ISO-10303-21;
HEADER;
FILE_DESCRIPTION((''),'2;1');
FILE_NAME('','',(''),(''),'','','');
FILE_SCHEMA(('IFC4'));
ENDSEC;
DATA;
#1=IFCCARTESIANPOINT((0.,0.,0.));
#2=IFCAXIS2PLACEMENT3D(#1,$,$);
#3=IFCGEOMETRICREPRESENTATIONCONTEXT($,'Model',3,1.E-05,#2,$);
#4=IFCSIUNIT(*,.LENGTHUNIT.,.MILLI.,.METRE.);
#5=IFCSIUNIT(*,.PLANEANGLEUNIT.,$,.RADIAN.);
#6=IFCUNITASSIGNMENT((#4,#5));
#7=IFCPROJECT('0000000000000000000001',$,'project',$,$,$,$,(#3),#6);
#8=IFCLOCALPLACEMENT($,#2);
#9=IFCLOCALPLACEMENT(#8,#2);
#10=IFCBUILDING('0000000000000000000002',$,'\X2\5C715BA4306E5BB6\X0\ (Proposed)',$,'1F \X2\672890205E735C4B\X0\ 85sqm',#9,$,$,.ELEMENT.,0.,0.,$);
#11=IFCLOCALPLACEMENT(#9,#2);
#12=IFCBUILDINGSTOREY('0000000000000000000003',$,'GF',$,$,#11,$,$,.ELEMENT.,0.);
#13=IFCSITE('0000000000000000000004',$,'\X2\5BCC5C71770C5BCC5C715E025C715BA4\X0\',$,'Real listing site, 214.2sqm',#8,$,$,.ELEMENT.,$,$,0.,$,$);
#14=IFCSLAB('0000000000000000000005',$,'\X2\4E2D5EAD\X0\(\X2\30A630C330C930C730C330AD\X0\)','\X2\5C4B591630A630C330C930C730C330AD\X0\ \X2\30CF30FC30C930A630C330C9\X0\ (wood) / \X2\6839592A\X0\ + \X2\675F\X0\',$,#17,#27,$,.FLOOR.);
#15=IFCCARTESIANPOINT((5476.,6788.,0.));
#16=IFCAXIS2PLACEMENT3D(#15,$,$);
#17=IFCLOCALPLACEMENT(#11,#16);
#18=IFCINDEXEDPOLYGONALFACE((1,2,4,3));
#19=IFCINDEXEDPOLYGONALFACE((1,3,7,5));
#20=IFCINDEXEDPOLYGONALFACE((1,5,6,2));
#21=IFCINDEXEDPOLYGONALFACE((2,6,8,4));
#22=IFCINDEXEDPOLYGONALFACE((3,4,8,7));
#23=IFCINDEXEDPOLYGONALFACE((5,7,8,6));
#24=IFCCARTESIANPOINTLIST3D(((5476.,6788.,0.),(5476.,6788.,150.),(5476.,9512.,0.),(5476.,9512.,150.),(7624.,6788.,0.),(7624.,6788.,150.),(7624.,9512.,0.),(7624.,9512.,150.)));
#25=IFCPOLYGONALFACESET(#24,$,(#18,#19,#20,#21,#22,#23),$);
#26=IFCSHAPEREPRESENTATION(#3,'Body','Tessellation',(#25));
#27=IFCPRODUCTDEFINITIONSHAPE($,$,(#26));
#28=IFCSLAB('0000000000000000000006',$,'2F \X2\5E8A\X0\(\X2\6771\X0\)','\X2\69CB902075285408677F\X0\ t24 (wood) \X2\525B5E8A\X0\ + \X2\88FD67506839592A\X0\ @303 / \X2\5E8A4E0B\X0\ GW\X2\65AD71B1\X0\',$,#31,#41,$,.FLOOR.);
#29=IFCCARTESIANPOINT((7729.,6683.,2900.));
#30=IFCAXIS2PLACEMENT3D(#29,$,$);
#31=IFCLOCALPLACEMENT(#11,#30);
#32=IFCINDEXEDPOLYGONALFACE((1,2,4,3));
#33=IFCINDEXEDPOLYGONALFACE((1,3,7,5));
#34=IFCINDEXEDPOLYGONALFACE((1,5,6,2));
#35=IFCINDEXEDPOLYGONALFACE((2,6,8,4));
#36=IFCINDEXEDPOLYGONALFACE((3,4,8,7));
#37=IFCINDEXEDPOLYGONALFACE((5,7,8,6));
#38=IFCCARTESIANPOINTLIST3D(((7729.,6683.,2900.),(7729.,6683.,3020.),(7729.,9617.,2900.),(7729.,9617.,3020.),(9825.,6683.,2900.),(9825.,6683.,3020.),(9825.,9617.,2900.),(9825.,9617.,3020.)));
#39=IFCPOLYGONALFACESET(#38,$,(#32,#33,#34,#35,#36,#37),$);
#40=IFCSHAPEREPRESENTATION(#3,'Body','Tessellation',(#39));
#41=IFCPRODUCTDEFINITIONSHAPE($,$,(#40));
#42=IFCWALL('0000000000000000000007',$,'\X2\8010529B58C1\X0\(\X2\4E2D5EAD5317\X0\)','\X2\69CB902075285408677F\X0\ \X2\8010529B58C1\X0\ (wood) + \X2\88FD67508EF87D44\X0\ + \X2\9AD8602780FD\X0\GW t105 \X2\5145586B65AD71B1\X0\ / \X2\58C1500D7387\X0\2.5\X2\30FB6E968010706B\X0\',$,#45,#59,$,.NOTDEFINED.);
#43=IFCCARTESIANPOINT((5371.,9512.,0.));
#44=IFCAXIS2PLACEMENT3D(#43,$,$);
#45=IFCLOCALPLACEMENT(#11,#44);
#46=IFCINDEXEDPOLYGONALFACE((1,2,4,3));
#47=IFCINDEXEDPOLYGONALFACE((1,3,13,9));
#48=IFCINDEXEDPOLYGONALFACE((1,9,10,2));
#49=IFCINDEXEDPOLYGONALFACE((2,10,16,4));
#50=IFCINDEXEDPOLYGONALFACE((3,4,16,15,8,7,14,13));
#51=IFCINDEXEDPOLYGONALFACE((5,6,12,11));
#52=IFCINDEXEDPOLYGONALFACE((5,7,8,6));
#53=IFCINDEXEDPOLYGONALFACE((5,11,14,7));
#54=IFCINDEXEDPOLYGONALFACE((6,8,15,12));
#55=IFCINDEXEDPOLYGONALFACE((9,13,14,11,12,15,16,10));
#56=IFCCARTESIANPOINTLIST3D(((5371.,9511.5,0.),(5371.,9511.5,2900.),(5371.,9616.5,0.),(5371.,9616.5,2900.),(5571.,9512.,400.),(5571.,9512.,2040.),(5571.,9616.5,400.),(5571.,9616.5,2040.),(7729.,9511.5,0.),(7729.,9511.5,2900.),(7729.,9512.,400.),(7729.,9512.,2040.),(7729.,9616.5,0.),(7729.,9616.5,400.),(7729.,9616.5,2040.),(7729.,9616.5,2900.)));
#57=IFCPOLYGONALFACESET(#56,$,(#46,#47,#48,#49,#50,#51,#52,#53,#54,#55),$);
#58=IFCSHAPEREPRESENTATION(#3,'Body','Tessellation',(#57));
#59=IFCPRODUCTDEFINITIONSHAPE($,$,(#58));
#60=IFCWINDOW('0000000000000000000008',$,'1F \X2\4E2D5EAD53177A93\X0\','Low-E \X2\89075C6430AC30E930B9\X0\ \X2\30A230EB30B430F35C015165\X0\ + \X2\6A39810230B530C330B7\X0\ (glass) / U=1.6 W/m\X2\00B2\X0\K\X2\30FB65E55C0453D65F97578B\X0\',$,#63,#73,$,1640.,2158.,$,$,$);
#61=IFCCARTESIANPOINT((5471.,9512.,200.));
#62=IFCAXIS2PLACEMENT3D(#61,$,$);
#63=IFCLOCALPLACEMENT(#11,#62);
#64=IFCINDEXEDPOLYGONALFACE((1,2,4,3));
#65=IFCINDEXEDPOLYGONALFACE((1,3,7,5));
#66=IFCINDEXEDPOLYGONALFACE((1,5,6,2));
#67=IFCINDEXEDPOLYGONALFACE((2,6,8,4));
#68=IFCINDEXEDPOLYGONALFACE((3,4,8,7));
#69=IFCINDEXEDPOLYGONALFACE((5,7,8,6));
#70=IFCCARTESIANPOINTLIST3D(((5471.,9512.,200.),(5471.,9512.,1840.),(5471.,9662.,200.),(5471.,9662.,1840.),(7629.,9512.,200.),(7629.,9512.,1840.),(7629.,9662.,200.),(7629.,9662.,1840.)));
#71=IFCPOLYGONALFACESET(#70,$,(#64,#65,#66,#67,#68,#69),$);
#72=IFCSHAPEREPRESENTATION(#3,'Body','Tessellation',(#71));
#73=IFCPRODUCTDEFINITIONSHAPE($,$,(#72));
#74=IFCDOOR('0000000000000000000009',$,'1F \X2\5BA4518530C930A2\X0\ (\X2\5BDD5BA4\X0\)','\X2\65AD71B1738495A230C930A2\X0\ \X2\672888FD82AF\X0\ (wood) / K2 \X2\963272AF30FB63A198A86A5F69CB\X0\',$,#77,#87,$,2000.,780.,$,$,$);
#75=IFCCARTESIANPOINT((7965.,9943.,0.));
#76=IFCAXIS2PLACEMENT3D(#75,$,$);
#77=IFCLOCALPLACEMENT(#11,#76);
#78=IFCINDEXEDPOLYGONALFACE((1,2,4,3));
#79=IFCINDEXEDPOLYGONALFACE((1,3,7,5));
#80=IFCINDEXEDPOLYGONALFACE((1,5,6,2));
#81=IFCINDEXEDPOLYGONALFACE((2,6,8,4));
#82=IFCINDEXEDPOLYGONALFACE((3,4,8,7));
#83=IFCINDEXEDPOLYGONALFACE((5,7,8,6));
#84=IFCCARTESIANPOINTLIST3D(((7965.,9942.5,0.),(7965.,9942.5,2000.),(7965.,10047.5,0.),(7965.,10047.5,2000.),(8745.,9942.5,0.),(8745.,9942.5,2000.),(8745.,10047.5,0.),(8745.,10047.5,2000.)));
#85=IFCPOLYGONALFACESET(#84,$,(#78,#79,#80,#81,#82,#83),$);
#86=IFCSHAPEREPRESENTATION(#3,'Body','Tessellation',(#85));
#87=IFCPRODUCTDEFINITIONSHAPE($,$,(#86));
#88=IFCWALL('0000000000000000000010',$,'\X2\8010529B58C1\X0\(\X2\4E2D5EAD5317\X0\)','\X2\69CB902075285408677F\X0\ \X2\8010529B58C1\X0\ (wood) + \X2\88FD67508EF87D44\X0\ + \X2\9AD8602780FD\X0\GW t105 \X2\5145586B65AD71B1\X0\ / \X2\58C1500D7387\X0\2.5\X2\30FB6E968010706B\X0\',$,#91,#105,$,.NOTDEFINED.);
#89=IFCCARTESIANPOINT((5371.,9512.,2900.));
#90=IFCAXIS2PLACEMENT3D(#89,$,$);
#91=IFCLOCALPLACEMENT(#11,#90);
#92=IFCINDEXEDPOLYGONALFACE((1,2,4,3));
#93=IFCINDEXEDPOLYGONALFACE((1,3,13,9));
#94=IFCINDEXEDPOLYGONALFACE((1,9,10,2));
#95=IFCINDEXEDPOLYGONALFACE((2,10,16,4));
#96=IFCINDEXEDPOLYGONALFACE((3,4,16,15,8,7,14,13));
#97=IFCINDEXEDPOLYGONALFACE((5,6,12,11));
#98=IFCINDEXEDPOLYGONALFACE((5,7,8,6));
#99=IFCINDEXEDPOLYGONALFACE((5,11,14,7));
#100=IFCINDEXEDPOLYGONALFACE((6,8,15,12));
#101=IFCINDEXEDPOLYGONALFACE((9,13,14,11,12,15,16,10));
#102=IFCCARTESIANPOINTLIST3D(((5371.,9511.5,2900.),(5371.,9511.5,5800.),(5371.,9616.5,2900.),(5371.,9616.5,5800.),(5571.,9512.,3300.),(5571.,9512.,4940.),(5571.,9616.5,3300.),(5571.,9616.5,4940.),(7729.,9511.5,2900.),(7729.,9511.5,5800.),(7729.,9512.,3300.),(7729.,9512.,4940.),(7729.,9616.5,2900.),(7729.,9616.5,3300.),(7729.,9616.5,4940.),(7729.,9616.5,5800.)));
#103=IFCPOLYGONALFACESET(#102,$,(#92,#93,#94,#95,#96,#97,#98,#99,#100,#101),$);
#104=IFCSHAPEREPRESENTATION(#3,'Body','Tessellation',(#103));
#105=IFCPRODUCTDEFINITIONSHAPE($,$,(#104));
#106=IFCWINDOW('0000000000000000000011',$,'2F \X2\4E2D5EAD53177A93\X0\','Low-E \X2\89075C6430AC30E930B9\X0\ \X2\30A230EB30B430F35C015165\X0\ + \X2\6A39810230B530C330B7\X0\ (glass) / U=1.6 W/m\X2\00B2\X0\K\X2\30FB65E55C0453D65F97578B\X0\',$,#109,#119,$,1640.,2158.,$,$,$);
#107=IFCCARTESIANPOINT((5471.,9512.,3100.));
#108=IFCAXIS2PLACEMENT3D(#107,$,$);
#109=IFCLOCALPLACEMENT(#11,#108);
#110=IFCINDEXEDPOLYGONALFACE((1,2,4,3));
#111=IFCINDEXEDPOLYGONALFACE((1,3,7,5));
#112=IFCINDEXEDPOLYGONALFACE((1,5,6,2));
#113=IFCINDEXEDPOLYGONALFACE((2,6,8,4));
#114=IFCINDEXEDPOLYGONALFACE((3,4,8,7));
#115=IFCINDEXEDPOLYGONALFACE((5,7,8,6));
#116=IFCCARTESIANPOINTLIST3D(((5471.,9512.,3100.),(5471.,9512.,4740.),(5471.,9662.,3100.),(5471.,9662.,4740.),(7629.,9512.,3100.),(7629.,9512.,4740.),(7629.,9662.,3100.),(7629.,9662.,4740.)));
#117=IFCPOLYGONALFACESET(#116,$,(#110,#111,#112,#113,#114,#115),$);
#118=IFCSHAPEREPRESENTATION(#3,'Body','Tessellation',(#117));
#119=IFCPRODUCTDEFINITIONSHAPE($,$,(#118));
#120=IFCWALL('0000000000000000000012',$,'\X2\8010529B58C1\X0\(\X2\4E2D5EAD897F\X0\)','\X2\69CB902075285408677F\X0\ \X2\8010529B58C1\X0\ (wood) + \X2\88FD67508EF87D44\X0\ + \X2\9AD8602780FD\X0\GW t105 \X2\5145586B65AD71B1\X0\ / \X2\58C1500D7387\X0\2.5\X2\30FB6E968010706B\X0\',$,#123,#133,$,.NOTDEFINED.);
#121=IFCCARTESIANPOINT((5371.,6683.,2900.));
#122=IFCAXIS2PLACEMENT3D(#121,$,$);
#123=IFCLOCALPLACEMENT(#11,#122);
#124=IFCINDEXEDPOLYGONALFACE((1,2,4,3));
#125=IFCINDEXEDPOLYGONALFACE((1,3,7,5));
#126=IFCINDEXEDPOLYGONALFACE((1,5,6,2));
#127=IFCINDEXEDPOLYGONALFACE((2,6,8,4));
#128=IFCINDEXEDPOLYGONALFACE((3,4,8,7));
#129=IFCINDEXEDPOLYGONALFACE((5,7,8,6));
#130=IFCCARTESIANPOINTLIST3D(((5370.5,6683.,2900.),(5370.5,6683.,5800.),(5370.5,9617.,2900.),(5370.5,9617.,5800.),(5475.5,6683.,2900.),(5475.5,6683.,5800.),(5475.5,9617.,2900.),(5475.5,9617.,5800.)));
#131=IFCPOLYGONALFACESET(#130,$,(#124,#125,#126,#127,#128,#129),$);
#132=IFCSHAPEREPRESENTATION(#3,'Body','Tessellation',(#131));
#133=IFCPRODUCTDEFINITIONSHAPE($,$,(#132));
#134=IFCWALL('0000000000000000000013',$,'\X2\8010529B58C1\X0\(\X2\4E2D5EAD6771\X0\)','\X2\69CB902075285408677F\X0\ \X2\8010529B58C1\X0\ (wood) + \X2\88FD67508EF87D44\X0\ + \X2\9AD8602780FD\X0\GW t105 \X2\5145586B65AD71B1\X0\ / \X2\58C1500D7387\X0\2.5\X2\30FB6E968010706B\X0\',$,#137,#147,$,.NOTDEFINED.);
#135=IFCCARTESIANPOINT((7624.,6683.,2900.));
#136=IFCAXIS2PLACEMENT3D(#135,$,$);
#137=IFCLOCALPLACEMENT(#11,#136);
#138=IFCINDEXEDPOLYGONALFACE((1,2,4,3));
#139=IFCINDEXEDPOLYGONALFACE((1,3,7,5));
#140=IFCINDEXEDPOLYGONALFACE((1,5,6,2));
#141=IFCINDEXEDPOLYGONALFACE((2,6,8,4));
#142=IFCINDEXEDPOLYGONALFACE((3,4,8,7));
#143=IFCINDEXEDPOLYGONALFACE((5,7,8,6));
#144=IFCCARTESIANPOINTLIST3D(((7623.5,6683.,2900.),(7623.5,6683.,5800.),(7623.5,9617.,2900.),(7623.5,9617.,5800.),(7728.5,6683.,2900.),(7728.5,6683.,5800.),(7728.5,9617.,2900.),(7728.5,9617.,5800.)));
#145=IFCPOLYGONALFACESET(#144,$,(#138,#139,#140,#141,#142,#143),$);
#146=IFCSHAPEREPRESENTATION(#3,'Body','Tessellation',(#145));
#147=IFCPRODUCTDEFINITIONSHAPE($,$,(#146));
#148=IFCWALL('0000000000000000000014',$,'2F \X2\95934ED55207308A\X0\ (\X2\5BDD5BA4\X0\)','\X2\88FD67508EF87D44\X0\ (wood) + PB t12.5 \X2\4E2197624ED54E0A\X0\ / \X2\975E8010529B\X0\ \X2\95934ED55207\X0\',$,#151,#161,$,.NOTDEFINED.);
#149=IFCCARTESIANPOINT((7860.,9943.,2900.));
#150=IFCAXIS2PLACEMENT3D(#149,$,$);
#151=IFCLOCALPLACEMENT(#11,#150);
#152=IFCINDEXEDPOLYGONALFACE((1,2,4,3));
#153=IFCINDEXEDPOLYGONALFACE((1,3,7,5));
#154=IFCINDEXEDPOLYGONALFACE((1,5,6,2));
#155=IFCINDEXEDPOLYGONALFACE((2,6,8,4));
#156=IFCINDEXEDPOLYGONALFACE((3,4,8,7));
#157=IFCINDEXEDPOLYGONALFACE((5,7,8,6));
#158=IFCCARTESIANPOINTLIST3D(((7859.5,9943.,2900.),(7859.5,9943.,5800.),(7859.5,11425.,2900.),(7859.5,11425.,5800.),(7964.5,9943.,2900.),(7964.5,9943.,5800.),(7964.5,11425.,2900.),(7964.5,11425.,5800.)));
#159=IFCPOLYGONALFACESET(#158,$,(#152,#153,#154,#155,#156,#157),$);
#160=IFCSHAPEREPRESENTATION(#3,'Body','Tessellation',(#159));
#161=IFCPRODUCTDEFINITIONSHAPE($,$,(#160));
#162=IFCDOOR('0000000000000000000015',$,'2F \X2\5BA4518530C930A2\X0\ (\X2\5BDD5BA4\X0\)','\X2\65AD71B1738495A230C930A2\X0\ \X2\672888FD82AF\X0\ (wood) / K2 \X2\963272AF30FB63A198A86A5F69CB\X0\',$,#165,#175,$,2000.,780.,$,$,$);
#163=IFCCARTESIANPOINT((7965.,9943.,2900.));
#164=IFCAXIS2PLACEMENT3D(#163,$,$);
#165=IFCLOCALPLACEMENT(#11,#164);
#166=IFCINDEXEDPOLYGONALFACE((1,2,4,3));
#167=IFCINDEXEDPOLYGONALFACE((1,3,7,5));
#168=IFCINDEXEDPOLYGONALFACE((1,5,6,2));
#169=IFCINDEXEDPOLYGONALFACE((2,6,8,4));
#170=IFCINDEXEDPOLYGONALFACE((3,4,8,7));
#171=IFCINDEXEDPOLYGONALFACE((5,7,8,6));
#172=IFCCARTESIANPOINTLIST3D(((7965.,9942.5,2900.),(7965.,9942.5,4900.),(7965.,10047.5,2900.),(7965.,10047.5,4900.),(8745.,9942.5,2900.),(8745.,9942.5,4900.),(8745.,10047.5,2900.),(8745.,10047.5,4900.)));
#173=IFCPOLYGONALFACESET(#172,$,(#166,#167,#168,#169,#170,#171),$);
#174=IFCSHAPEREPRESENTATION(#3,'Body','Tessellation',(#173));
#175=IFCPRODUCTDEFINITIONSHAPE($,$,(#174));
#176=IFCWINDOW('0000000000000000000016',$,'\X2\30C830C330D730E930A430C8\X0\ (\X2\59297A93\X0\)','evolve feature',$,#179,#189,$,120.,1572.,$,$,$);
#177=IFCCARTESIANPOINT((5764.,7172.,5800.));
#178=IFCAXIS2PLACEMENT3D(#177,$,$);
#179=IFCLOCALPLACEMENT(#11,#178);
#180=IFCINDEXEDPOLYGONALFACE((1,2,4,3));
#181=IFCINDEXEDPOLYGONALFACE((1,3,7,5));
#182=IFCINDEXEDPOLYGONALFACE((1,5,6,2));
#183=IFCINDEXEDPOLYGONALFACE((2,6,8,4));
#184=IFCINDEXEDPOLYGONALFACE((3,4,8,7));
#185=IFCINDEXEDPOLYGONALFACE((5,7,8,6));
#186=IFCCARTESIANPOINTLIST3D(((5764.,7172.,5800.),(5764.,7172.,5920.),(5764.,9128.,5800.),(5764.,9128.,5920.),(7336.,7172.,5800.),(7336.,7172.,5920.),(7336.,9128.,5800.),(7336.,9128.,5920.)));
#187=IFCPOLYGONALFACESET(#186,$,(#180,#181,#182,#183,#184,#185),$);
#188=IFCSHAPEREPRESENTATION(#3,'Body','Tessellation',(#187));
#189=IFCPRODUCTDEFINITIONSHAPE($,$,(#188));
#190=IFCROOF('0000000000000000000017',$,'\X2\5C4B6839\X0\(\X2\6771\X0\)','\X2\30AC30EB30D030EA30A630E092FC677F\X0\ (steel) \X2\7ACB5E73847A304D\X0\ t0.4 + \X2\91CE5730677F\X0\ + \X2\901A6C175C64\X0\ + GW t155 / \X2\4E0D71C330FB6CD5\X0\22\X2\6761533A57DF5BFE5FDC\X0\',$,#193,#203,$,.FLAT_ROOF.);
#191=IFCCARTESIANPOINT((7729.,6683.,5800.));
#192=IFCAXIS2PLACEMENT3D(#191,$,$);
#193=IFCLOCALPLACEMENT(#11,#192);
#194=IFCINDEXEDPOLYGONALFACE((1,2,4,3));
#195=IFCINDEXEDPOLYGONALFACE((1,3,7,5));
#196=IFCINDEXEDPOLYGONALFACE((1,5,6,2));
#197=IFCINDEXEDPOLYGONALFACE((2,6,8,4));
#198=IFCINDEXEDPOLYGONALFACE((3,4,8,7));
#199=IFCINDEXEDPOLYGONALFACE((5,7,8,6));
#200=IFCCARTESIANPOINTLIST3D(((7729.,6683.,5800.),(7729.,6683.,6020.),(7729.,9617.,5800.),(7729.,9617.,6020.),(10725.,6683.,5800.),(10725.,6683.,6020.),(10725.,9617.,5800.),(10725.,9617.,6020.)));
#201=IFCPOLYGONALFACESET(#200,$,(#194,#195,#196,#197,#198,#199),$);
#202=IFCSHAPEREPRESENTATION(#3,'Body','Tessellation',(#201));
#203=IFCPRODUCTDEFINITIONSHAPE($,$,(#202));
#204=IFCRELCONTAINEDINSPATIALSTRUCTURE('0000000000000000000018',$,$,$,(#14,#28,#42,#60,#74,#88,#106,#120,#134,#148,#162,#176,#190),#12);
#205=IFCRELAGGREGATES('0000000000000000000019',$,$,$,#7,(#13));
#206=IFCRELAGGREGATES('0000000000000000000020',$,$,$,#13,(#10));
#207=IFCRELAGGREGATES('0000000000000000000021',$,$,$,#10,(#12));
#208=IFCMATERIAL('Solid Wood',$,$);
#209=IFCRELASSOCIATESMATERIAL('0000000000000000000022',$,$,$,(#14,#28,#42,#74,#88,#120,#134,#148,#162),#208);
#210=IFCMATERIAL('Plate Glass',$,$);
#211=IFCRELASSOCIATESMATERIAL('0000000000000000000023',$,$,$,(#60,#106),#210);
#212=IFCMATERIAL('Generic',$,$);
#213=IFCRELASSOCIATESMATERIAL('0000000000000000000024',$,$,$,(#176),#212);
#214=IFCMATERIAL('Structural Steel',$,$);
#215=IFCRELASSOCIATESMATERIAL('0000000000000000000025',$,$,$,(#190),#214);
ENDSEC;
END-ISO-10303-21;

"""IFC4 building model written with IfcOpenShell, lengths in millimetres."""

from ifc_helpers import new_model, si_unit, frame, frame_2d, origin, place, context, project, spatial, rectangle, extrude, material, element, fill, save


model = new_model("IFC4")

# Units and contexts
model_context = context("Model", 3, precision=1e-05, world=origin())
ifc_project = project(units=[si_unit("LENGTHUNIT", "METRE", prefix="MILLI"), si_unit("PLANEANGLEUNIT", "RADIAN")], contexts=[model_context])

# Site, building, storey
site_placement = place(None, origin())
site = spatial("IfcSite", under=ifc_project, at=site_placement, Name="富山県富山市山室", ObjectType="Real listing site, 214.2sqm", CompositionType="ELEMENT", RefElevation=0.0)
building_placement = place(site_placement, origin())
building = spatial("IfcBuilding", under=site, at=building_placement, Name="山室の家 (Proposed)", ObjectType="1F 木造平屋 85sqm", CompositionType="ELEMENT", ElevationOfRefHeight=0.0, ElevationOfTerrain=0.0)
storey_placement = place(building_placement, origin())
storey = spatial("IfcBuildingStorey", under=building, at=storey_placement, Name="GF", CompositionType="ELEMENT", Elevation=0.0)

# Slabs
ifc_material_1 = material(Name="Solid Wood")
slab_1_placement = place(storey_placement, frame((5476.0, 6788.0, 0.0)))
element("IfcSlab", 1, at=slab_1_placement, inside=storey, material=ifc_material_1, Name="中庭(ウッドデッキ)", Description="屋外ウッドデッキ ハードウッド (wood) / 根太 + 束", PredefinedType="FLOOR", context=model_context, shape_type="SweptSolid", body=[
    extrude(rectangle(XDim=2148.0, YDim=2724.0, at=frame_2d((1074.0, 1362.0))), frame((5476.0, 6788.0, 0.0)), (0.0, 0.0, 1.0), 150.0),
])
slab_2_placement = place(storey_placement, frame((7729.0, 6683.0, 2900.0)))
element("IfcSlab", 2, at=slab_2_placement, inside=storey, material=ifc_material_1, Name="2F 床(東)", Description="構造用合板 t24 (wood) 剛床 + 製材根太 @303 / 床下 GW断熱", PredefinedType="FLOOR", context=model_context, shape_type="SweptSolid", body=[
    extrude(rectangle(XDim=2096.0, YDim=2934.0, at=frame_2d((1048.0, 1467.0))), frame((7729.0, 6683.0, 2900.0)), (0.0, 0.0, 1.0), 120.0),
])

# Wall, opening, window
wall_1_placement = place(storey_placement, frame((5371.0, 9512.0, 0.0)))
wall_1 = element("IfcWall", 3, at=wall_1_placement, inside=storey, material=ifc_material_1, Name="耐力壁(中庭北)", Description="構造用合板 耐力壁 (wood) + 製材軸組 + 高性能GW t105 充填断熱 / 壁倍率2.5・準耐火", PredefinedType="NOTDEFINED", context=model_context, shape_type="SweptSolid", body=[
    extrude(rectangle(XDim=2358.0, YDim=105.0, at=frame_2d((1179.0, 52.0))), frame((5371.0, 9512.0, 0.0)), (0.0, 0.0, 1.0), 2900.0),
])
opening_1_placement = place(storey_placement, frame((5471.0, 9512.0, 200.0)))
opening_1 = element("IfcOpeningElement", 4, at=opening_1_placement, cuts=wall_1, PredefinedType="NOTDEFINED", context=model_context, shape_type="SweptSolid", body=[
    extrude(rectangle(XDim=2158.0, YDim=150.0, at=frame_2d((1079.0, 75.0))), frame((5471.0, 9512.0, 200.0)), (0.0, 0.0, 1.0), 1640.0),
])
ifc_material_2 = material(Name="Plate Glass")
window_1_placement = place(storey_placement, frame((5471.0, 9512.0, 200.0)))
window_1 = element("IfcWindow", 5, at=window_1_placement, inside=storey, material=ifc_material_2, Name="1F 中庭北窓", Description="Low-E 複層ガラス アルゴン封入 + 樹脂サッシ (glass) / U=1.6 W/m²K・日射取得型", OverallHeight=1640.0, OverallWidth=2158.0, context=model_context, shape_type="SweptSolid", body=[
    extrude(rectangle(XDim=2158.0, YDim=150.0, at=frame_2d((1079.0, 75.0))), frame((5471.0, 9512.0, 200.0)), (0.0, 0.0, 1.0), 1640.0),
])
fill(opening_1, window_1)

# Door
door_1_placement = place(storey_placement, frame((7965.0, 9943.0, 0.0)))
element("IfcDoor", 6, at=door_1_placement, inside=storey, material=ifc_material_1, Name="1F 室内ドア (寝室)", Description="断熱玄関ドア 木製芯 (wood) / K2 防犯・採風機構", OverallHeight=2000.0, OverallWidth=780.0, context=model_context, shape_type="SweptSolid", body=[
    extrude(rectangle(XDim=780.0, YDim=105.0, at=frame_2d((390.0, 52.0))), frame((7965.0, 9943.0, 0.0)), (0.0, 0.0, 1.0), 2000.0),
])

# Wall, opening, window
wall_2_placement = place(storey_placement, frame((5371.0, 9512.0, 2900.0)))
wall_2 = element("IfcWall", 7, at=wall_2_placement, inside=storey, material=ifc_material_1, Name="耐力壁(中庭北)", Description="構造用合板 耐力壁 (wood) + 製材軸組 + 高性能GW t105 充填断熱 / 壁倍率2.5・準耐火", PredefinedType="NOTDEFINED", context=model_context, shape_type="SweptSolid", body=[
    extrude(rectangle(XDim=2358.0, YDim=105.0, at=frame_2d((1179.0, 52.0))), frame((5371.0, 9512.0, 2900.0)), (0.0, 0.0, 1.0), 2900.0),
])
opening_2_placement = place(storey_placement, frame((5471.0, 9512.0, 3100.0)))
opening_2 = element("IfcOpeningElement", 8, at=opening_2_placement, cuts=wall_2, PredefinedType="NOTDEFINED", context=model_context, shape_type="SweptSolid", body=[
    extrude(rectangle(XDim=2158.0, YDim=150.0, at=frame_2d((1079.0, 75.0))), frame((5471.0, 9512.0, 3100.0)), (0.0, 0.0, 1.0), 1640.0),
])
window_2_placement = place(storey_placement, frame((5471.0, 9512.0, 3100.0)))
window_2 = element("IfcWindow", 9, at=window_2_placement, inside=storey, material=ifc_material_2, Name="2F 中庭北窓", Description="Low-E 複層ガラス アルゴン封入 + 樹脂サッシ (glass) / U=1.6 W/m²K・日射取得型", OverallHeight=1640.0, OverallWidth=2158.0, context=model_context, shape_type="SweptSolid", body=[
    extrude(rectangle(XDim=2158.0, YDim=150.0, at=frame_2d((1079.0, 75.0))), frame((5471.0, 9512.0, 3100.0)), (0.0, 0.0, 1.0), 1640.0),
])
fill(opening_2, window_2)

# Walls
wall_3_placement = place(storey_placement, frame((5371.0, 6683.0, 2900.0)))
element("IfcWall", 10, at=wall_3_placement, inside=storey, material=ifc_material_1, Name="耐力壁(中庭西)", Description="構造用合板 耐力壁 (wood) + 製材軸組 + 高性能GW t105 充填断熱 / 壁倍率2.5・準耐火", PredefinedType="NOTDEFINED", context=model_context, shape_type="SweptSolid", body=[
    extrude(rectangle(XDim=105.0, YDim=2934.0, at=frame_2d((52.0, 1467.0))), frame((5371.0, 6683.0, 2900.0)), (0.0, 0.0, 1.0), 2900.0),
])
wall_4_placement = place(storey_placement, frame((7624.0, 6683.0, 2900.0)))
element("IfcWall", 11, at=wall_4_placement, inside=storey, material=ifc_material_1, Name="耐力壁(中庭東)", Description="構造用合板 耐力壁 (wood) + 製材軸組 + 高性能GW t105 充填断熱 / 壁倍率2.5・準耐火", PredefinedType="NOTDEFINED", context=model_context, shape_type="SweptSolid", body=[
    extrude(rectangle(XDim=105.0, YDim=2934.0, at=frame_2d((52.0, 1467.0))), frame((7624.0, 6683.0, 2900.0)), (0.0, 0.0, 1.0), 2900.0),
])
wall_5_placement = place(storey_placement, frame((7860.0, 9943.0, 2900.0)))
element("IfcWall", 12, at=wall_5_placement, inside=storey, material=ifc_material_1, Name="2F 間仕切り (寝室)", Description="製材軸組 (wood) + PB t12.5 両面仕上 / 非耐力 間仕切", PredefinedType="NOTDEFINED", context=model_context, shape_type="SweptSolid", body=[
    extrude(rectangle(XDim=105.0, YDim=1482.0, at=frame_2d((52.0, 741.0))), frame((7860.0, 9943.0, 2900.0)), (0.0, 0.0, 1.0), 2900.0),
])

# Door
door_2_placement = place(storey_placement, frame((7965.0, 9943.0, 2900.0)))
element("IfcDoor", 13, at=door_2_placement, inside=storey, material=ifc_material_1, Name="2F 室内ドア (寝室)", Description="断熱玄関ドア 木製芯 (wood) / K2 防犯・採風機構", OverallHeight=2000.0, OverallWidth=780.0, context=model_context, shape_type="SweptSolid", body=[
    extrude(rectangle(XDim=780.0, YDim=105.0, at=frame_2d((390.0, 52.0))), frame((7965.0, 9943.0, 2900.0)), (0.0, 0.0, 1.0), 2000.0),
])

# Window
ifc_material_3 = material(Name="Generic")
window_3_placement = place(storey_placement, frame((5764.0, 7172.0, 5800.0)))
element("IfcWindow", 14, at=window_3_placement, inside=storey, material=ifc_material_3, Name="トップライト (天窓)", Description="evolve feature", OverallHeight=120.0, OverallWidth=1572.0, context=model_context, shape_type="SweptSolid", body=[
    extrude(rectangle(XDim=1572.0, YDim=1956.0, at=frame_2d((786.0, 978.0))), frame((5764.0, 7172.0, 5800.0)), (0.0, 0.0, 1.0), 120.0),
])

# Roof
ifc_material_4 = material(Name="Structural Steel")
roof_placement = place(storey_placement, frame((7729.0, 6683.0, 5800.0)))
element("IfcRoof", 15, at=roof_placement, inside=storey, material=ifc_material_4, Name="屋根(東)", Description="ガルバリウム鋼板 (steel) 立平葺き t0.4 + 野地板 + 通気層 + GW t155 / 不燃・法22条区域対応", PredefinedType="FLAT_ROOF", context=model_context, shape_type="SweptSolid", body=[
    extrude(rectangle(XDim=2996.0, YDim=2934.0, at=frame_2d((1498.0, 1467.0))), frame((7729.0, 6683.0, 5800.0)), (0.0, 0.0, 1.0), 220.0),
])

save(model, "model.ifc")
